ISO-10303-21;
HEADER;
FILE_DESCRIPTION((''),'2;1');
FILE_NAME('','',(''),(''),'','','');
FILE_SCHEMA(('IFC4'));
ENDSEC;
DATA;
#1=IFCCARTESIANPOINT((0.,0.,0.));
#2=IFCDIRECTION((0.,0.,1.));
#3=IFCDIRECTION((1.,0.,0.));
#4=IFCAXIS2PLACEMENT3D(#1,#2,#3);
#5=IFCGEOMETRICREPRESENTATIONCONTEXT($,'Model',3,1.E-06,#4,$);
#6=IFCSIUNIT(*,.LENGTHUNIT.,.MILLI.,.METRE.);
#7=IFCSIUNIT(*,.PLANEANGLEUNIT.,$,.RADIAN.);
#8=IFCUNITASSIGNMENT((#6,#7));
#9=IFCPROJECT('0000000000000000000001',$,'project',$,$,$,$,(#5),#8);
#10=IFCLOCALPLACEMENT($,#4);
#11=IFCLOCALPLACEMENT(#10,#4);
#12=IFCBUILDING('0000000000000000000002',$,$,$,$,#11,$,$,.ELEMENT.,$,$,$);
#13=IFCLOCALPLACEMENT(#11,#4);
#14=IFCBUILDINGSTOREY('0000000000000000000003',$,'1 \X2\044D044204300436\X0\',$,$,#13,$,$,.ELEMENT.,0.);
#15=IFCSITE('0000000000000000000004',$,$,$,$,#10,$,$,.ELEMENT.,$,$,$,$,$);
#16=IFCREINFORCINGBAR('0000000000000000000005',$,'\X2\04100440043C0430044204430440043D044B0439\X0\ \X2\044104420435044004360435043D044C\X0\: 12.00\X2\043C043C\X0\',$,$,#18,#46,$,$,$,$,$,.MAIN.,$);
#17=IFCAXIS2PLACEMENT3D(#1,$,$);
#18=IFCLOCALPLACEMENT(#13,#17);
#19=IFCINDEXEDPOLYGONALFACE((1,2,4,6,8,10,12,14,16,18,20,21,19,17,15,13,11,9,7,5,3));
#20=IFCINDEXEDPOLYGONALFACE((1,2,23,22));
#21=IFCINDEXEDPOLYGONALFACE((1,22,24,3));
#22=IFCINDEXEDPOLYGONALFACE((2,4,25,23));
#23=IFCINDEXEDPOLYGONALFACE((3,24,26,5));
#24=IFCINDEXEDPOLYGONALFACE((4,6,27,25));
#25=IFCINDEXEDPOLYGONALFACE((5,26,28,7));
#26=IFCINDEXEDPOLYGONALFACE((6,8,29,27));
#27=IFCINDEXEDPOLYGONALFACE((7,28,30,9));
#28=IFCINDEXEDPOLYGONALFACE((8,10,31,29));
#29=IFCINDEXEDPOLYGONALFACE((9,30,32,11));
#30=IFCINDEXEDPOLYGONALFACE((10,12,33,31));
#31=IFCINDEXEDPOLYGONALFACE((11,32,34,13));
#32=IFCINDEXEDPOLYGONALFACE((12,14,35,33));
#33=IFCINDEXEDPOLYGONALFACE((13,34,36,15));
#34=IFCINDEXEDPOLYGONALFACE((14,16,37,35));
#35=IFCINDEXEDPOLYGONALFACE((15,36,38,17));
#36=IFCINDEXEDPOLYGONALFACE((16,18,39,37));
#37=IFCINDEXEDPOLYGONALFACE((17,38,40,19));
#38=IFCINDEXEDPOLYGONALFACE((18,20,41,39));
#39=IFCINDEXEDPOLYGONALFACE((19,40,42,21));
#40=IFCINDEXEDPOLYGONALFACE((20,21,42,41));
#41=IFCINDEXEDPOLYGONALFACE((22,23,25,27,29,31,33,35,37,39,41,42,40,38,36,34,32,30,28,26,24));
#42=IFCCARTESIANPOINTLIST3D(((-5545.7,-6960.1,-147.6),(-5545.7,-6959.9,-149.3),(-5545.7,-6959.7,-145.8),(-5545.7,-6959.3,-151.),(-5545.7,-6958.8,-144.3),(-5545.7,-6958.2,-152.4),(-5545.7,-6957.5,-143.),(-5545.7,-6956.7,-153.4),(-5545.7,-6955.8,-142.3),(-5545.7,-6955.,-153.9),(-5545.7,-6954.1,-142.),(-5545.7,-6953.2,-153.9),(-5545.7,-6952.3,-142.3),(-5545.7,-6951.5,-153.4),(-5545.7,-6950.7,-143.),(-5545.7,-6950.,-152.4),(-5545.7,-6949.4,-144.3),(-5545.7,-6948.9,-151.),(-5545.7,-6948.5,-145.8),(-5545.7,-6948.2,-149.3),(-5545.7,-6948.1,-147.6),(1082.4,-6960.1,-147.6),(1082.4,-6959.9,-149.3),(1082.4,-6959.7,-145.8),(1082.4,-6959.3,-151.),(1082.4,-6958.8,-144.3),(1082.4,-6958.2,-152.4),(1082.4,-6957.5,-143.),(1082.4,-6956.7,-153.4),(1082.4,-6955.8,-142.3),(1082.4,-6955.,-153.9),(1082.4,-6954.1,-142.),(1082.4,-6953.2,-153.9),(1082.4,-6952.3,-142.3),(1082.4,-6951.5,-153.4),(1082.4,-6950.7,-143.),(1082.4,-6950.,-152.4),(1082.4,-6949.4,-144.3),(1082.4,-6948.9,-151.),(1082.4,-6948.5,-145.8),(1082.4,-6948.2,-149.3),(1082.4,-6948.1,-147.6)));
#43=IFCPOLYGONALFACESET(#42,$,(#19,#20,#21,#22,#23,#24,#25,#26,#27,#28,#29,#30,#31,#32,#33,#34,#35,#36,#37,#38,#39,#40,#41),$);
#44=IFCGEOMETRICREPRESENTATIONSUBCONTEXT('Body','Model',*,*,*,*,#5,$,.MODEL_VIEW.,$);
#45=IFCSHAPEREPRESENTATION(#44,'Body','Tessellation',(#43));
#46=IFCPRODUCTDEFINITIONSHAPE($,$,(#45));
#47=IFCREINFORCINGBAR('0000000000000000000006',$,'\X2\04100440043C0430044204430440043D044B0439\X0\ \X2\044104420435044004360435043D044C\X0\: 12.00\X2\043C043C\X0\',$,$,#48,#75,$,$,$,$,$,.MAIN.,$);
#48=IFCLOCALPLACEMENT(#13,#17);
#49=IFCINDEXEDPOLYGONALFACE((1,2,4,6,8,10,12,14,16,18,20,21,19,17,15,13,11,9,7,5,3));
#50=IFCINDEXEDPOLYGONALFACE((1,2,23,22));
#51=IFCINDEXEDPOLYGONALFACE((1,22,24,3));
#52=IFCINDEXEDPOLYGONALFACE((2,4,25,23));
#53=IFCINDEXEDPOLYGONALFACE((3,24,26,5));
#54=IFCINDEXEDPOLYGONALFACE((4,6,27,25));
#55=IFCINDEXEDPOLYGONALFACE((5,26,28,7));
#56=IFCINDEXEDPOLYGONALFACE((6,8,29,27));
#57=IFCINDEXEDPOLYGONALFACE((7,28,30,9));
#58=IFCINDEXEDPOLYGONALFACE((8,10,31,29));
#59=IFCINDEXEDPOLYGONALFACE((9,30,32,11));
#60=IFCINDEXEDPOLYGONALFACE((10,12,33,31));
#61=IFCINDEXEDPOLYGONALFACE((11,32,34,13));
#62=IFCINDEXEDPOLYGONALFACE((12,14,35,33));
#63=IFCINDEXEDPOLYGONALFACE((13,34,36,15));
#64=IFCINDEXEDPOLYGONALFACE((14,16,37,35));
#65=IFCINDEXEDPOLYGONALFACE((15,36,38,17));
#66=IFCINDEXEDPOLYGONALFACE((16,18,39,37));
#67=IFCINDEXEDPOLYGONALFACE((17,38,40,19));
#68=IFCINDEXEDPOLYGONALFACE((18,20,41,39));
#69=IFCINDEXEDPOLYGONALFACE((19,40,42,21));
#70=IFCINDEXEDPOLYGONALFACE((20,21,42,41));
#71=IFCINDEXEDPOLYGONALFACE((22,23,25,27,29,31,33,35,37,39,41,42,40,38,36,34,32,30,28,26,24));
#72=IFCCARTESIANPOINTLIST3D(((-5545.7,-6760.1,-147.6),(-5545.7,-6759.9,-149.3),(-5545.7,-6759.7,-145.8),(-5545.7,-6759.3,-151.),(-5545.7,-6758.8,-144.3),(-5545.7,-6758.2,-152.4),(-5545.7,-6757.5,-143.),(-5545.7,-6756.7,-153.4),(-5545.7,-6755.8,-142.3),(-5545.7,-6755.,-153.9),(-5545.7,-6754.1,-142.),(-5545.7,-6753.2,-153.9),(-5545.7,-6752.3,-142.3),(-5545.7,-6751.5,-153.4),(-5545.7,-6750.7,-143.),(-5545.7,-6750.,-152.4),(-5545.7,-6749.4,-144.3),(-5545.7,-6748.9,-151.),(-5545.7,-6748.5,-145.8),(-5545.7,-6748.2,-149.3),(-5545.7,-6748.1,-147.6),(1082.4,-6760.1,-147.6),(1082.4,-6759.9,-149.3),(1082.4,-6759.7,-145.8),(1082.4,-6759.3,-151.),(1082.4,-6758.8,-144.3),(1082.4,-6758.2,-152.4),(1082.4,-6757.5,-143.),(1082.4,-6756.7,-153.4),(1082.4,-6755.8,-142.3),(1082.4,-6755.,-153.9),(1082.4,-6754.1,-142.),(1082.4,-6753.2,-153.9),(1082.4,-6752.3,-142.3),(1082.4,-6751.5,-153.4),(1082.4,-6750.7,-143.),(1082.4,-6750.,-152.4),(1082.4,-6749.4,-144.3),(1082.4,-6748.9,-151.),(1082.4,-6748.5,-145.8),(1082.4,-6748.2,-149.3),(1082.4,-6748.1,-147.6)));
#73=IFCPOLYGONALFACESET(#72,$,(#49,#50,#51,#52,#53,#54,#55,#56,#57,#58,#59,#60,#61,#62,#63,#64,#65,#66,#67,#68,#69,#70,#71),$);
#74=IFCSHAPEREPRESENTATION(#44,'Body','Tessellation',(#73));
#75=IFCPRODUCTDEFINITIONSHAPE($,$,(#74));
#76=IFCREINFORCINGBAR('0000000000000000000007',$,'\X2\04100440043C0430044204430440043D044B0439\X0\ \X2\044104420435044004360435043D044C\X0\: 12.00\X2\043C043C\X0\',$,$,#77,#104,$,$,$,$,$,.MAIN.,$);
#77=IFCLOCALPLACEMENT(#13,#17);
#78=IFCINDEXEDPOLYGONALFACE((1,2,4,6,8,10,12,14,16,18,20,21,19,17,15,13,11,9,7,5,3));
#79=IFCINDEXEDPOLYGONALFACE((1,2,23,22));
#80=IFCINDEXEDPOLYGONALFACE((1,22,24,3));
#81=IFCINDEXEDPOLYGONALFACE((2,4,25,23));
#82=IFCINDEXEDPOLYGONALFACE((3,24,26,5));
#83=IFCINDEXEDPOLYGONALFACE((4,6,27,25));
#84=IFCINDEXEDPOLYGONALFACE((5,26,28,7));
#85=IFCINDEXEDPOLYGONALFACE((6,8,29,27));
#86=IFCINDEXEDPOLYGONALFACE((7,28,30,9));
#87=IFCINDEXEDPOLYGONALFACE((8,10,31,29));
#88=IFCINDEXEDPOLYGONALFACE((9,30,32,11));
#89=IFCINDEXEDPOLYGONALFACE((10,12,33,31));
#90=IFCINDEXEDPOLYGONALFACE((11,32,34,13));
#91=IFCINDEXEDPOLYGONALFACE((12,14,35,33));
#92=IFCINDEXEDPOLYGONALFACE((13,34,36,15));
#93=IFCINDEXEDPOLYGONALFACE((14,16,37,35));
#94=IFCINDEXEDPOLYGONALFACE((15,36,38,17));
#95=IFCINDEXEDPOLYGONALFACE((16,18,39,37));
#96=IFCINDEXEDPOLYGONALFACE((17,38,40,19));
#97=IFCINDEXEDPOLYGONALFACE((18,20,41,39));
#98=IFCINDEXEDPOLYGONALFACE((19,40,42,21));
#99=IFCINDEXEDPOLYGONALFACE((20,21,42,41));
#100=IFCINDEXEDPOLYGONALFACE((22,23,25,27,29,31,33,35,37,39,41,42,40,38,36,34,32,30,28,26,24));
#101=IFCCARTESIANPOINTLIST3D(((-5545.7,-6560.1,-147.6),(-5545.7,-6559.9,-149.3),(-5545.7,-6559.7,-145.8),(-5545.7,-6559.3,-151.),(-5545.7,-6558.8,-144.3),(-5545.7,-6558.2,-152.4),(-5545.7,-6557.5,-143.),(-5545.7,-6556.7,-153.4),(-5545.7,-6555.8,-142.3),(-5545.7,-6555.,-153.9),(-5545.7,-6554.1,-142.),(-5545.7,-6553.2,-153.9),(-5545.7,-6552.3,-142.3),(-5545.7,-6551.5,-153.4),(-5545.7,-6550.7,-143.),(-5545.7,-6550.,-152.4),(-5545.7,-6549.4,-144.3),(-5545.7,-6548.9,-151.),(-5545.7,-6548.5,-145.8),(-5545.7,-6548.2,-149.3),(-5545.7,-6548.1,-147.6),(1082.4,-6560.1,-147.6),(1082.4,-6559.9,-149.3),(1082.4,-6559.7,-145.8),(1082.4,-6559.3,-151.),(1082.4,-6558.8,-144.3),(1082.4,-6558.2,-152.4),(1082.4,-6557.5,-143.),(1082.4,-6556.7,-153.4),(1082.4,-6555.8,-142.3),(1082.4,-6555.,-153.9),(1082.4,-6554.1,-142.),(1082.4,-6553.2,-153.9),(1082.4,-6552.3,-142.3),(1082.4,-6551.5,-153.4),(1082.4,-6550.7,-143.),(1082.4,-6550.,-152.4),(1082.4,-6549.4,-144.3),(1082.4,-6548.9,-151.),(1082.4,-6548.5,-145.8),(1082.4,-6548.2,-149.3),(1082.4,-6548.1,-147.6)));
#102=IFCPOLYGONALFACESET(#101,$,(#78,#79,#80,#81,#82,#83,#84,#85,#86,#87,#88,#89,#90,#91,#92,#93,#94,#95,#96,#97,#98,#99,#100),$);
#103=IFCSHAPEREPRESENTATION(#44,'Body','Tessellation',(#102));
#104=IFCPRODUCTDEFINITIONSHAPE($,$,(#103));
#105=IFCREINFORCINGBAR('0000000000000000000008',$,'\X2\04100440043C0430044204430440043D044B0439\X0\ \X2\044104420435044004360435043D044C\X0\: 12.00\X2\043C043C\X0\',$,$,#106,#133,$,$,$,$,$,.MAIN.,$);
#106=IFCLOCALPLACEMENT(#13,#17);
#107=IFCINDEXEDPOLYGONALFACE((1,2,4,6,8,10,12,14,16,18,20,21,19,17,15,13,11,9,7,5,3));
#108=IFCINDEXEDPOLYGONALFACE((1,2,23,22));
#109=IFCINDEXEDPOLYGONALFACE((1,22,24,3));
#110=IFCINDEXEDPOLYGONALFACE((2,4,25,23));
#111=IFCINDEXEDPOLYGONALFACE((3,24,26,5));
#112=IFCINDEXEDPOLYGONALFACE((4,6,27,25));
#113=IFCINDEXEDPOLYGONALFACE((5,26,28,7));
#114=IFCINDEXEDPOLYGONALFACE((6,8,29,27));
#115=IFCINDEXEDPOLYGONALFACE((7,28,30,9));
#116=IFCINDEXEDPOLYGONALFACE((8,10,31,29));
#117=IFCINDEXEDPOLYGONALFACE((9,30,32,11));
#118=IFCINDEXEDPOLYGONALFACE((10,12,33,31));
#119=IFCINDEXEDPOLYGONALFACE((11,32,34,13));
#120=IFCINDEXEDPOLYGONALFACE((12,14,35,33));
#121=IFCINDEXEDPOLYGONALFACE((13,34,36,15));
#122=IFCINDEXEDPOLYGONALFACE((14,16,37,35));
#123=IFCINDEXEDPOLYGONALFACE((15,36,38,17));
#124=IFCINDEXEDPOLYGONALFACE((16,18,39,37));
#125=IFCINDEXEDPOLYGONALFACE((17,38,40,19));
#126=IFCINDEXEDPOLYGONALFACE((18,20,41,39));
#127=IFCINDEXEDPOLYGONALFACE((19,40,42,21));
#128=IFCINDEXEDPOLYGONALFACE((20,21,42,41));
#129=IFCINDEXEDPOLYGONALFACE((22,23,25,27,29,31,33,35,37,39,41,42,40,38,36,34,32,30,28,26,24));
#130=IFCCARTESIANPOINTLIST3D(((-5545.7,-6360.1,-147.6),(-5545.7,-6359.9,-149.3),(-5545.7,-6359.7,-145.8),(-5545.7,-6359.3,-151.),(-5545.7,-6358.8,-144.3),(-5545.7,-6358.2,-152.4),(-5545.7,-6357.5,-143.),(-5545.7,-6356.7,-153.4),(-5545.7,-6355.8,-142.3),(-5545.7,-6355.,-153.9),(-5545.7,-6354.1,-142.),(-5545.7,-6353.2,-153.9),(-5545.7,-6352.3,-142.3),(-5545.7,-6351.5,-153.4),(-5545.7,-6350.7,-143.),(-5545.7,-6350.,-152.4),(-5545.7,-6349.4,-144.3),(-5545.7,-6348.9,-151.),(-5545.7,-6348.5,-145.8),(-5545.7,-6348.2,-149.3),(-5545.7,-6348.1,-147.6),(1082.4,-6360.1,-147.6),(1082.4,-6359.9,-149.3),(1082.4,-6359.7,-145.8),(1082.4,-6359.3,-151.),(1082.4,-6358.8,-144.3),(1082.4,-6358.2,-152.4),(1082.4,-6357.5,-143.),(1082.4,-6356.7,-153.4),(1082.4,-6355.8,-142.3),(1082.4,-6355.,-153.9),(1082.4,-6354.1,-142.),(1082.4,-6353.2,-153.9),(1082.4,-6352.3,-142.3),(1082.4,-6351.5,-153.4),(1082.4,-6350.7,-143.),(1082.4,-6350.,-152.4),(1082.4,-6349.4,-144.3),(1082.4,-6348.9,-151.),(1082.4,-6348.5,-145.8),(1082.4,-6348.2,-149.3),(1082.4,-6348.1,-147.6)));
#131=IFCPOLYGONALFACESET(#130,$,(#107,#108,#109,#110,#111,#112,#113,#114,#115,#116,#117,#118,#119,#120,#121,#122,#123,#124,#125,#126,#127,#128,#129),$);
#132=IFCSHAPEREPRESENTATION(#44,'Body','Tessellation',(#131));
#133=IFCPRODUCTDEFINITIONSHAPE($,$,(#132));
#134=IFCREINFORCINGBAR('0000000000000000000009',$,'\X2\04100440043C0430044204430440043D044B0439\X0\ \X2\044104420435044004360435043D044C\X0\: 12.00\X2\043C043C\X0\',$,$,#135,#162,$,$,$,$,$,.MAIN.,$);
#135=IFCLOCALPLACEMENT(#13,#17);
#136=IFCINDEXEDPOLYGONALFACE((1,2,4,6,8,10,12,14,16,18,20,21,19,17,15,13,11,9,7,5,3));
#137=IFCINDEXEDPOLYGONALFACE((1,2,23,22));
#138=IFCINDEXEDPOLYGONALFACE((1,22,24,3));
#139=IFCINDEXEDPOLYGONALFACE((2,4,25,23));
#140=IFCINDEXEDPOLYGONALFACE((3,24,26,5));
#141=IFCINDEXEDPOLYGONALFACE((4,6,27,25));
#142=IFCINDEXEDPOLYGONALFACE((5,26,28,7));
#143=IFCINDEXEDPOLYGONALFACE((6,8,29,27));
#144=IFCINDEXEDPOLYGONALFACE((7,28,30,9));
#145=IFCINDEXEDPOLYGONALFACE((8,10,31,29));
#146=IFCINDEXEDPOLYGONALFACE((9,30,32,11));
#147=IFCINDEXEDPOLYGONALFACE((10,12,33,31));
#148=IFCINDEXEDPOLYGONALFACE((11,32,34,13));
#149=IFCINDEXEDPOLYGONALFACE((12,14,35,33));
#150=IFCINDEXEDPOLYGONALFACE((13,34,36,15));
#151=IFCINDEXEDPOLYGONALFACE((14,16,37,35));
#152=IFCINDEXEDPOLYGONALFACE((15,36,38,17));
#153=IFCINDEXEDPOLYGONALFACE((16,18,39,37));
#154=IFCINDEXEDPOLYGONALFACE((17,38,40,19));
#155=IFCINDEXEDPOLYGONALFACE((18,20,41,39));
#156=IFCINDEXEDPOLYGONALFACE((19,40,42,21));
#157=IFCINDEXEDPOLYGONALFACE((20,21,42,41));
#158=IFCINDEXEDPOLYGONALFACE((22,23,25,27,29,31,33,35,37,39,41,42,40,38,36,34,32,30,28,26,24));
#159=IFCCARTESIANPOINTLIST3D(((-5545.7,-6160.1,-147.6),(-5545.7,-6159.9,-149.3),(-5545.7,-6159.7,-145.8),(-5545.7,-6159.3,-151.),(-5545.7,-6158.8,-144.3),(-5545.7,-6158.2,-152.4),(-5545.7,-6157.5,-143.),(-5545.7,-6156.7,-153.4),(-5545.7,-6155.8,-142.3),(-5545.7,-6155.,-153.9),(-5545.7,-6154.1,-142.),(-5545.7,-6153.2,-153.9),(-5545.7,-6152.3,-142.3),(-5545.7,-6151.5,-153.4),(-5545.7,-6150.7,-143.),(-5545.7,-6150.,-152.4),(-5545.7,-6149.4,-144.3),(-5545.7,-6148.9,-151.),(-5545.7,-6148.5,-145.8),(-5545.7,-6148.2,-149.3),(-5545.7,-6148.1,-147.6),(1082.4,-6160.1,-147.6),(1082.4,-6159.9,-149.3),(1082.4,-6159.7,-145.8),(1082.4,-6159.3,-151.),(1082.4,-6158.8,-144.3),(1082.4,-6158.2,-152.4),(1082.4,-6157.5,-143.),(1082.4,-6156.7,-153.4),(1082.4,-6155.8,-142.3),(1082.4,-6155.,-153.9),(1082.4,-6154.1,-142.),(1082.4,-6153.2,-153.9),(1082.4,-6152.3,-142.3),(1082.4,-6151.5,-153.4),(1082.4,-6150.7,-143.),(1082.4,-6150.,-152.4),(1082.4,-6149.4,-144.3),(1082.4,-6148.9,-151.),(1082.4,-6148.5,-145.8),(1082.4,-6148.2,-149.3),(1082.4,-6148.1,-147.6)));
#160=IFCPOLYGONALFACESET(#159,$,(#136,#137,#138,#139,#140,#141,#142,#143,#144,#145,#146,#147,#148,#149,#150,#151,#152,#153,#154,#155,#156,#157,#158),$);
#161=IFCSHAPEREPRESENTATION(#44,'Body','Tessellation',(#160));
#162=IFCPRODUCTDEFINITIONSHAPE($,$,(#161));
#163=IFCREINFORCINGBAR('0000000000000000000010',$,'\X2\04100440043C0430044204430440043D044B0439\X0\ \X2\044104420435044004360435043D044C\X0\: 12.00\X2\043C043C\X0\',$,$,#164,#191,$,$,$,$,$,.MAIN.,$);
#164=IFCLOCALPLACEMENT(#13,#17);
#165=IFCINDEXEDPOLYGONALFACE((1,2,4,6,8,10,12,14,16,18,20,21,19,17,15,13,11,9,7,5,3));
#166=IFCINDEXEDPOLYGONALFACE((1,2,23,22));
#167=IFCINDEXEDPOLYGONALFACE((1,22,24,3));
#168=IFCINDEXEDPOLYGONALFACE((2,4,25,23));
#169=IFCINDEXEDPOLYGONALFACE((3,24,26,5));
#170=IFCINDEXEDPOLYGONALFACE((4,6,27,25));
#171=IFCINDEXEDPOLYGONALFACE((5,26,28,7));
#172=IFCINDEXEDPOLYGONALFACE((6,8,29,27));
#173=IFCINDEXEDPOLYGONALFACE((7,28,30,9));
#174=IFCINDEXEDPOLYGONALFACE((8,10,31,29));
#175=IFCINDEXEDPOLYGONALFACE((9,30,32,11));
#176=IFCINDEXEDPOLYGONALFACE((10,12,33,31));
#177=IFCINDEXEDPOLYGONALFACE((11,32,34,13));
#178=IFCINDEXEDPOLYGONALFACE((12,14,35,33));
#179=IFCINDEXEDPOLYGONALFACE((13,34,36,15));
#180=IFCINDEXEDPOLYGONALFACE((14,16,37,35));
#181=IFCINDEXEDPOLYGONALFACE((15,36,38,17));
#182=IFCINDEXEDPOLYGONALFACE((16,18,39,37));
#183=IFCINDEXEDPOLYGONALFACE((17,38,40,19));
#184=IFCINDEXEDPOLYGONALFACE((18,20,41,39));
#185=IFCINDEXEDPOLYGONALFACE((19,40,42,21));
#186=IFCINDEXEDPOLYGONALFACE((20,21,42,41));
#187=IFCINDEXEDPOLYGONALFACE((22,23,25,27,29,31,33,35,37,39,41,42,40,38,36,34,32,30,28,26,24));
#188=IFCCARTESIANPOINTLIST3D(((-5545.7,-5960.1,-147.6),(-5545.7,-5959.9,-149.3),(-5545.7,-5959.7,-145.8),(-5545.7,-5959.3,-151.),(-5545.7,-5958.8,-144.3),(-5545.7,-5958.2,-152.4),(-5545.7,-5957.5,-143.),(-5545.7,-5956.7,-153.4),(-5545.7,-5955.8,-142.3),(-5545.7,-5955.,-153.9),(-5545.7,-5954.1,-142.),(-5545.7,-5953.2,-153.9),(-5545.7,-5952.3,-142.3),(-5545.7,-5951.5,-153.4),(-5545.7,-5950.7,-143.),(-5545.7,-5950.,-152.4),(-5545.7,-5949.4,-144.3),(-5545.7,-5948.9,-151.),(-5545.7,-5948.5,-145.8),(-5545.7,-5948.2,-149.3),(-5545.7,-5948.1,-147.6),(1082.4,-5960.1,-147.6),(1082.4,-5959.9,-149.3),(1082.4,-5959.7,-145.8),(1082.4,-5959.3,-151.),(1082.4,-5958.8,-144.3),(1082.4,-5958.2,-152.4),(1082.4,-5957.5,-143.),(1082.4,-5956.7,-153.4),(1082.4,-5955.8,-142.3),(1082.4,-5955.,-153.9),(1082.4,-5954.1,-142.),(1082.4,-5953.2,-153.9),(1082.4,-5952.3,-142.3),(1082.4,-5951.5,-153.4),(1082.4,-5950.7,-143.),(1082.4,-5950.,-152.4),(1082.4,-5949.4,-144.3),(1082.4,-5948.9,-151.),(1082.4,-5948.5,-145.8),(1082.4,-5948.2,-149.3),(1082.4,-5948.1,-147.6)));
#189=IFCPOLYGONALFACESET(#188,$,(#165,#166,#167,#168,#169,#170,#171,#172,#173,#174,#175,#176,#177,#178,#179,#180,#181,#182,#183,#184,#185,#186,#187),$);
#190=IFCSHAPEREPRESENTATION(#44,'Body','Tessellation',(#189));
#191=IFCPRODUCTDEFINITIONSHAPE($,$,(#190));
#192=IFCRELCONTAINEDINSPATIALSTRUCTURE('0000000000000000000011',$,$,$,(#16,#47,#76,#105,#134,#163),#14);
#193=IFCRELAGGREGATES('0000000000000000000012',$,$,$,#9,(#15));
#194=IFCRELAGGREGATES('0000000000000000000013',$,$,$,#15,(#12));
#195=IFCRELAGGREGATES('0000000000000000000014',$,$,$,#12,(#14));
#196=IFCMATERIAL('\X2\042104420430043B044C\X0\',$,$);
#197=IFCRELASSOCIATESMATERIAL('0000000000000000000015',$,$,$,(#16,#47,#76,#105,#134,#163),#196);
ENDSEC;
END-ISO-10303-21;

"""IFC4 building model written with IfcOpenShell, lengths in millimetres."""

from ifc_helpers import new_model, entity, si_unit, origin_with_axes, place, context, subcontext, project, spatial, source, transform, mapped, material, element, save


model = new_model("IFC4")

# Units and contexts
model_context = context("Model", 3, precision=1e-06, world=origin_with_axes())
body_context = subcontext(model_context, "Body", "Model", "MODEL_VIEW")
ifc_project = project(units=[si_unit("LENGTHUNIT", "METRE", prefix="MILLI"), si_unit("PLANEANGLEUNIT", "RADIAN")], contexts=[model_context])

# Site, building, storey
site_placement = place(None, origin_with_axes())
site = spatial("IfcSite", under=ifc_project, at=site_placement, CompositionType="ELEMENT")
building_placement = place(site_placement, origin_with_axes())
building = spatial("IfcBuilding", under=site, at=building_placement, CompositionType="ELEMENT")
storey_placement = place(building_placement, origin_with_axes())
storey = spatial("IfcBuildingStorey", under=building, at=storey_placement, Name="1 этаж", CompositionType="ELEMENT", Elevation=0.0)

# Shared definitions
ifc_material_1 = material(Name="Сталь")

# Reinforcing bars
shared_shape_1 = source(origin_with_axes(), body_context, "Body", "AdvancedSweptSolid", [
    entity("IfcSweptDiskSolid", entity("IfcIndexedPolyCurve", entity("IfcCartesianPointList3D", [[0.0, 0.0, 0.0], [6628.1, 0.0, 0.0]]), [entity("IfcLineIndex", [1, 2])]), 6.0),
])
reinforcing_bar_1_placement = place(storey_placement, origin_with_axes())
element("IfcReinforcingBar", 1, at=reinforcing_bar_1_placement, inside=storey, material=ifc_material_1, Name="Арматурный стержень: 12.00мм", PredefinedType="MAIN", context=body_context, shape_type="MappedRepresentation", body=[
    mapped(shared_shape_1, transform((-5545.7, -6954.1, -148.0), x_axis=(1.0, 0.0, 0.0), y_axis=(0.0, 1.0, 0.0), z_axis=(0.0, 0.0, 1.0), scale=1.0)),
])
reinforcing_bar_2_placement = place(storey_placement, origin_with_axes())
element("IfcReinforcingBar", 2, at=reinforcing_bar_2_placement, inside=storey, material=ifc_material_1, Name="Арматурный стержень: 12.00мм", PredefinedType="MAIN", context=body_context, shape_type="MappedRepresentation", body=[
    mapped(shared_shape_1, transform((-5545.7, -6754.1, -148.0), x_axis=(1.0, 0.0, 0.0), y_axis=(0.0, 1.0, 0.0), z_axis=(0.0, 0.0, 1.0), scale=1.0)),
])
reinforcing_bar_3_placement = place(storey_placement, origin_with_axes())
element("IfcReinforcingBar", 3, at=reinforcing_bar_3_placement, inside=storey, material=ifc_material_1, Name="Арматурный стержень: 12.00мм", PredefinedType="MAIN", context=body_context, shape_type="MappedRepresentation", body=[
    mapped(shared_shape_1, transform((-5545.7, -6554.1, -148.0), x_axis=(1.0, 0.0, 0.0), y_axis=(0.0, 1.0, 0.0), z_axis=(0.0, 0.0, 1.0), scale=1.0)),
])
reinforcing_bar_4_placement = place(storey_placement, origin_with_axes())
element("IfcReinforcingBar", 4, at=reinforcing_bar_4_placement, inside=storey, material=ifc_material_1, Name="Арматурный стержень: 12.00мм", PredefinedType="MAIN", context=body_context, shape_type="MappedRepresentation", body=[
    mapped(shared_shape_1, transform((-5545.7, -6354.1, -148.0), x_axis=(1.0, 0.0, 0.0), y_axis=(0.0, 1.0, 0.0), z_axis=(0.0, 0.0, 1.0), scale=1.0)),
])
reinforcing_bar_5_placement = place(storey_placement, origin_with_axes())
element("IfcReinforcingBar", 5, at=reinforcing_bar_5_placement, inside=storey, material=ifc_material_1, Name="Арматурный стержень: 12.00мм", PredefinedType="MAIN", context=body_context, shape_type="MappedRepresentation", body=[
    mapped(shared_shape_1, transform((-5545.7, -6154.1, -148.0), x_axis=(1.0, 0.0, 0.0), y_axis=(0.0, 1.0, 0.0), z_axis=(0.0, 0.0, 1.0), scale=1.0)),
])
reinforcing_bar_6_placement = place(storey_placement, origin_with_axes())
element("IfcReinforcingBar", 6, at=reinforcing_bar_6_placement, inside=storey, material=ifc_material_1, Name="Арматурный стержень: 12.00мм", PredefinedType="MAIN", context=body_context, shape_type="MappedRepresentation", body=[
    mapped(shared_shape_1, transform((-5545.7, -5954.1, -148.0), x_axis=(1.0, 0.0, 0.0), y_axis=(0.0, 1.0, 0.0), z_axis=(0.0, 0.0, 1.0), scale=1.0)),
])

save(model, "model.ifc")
